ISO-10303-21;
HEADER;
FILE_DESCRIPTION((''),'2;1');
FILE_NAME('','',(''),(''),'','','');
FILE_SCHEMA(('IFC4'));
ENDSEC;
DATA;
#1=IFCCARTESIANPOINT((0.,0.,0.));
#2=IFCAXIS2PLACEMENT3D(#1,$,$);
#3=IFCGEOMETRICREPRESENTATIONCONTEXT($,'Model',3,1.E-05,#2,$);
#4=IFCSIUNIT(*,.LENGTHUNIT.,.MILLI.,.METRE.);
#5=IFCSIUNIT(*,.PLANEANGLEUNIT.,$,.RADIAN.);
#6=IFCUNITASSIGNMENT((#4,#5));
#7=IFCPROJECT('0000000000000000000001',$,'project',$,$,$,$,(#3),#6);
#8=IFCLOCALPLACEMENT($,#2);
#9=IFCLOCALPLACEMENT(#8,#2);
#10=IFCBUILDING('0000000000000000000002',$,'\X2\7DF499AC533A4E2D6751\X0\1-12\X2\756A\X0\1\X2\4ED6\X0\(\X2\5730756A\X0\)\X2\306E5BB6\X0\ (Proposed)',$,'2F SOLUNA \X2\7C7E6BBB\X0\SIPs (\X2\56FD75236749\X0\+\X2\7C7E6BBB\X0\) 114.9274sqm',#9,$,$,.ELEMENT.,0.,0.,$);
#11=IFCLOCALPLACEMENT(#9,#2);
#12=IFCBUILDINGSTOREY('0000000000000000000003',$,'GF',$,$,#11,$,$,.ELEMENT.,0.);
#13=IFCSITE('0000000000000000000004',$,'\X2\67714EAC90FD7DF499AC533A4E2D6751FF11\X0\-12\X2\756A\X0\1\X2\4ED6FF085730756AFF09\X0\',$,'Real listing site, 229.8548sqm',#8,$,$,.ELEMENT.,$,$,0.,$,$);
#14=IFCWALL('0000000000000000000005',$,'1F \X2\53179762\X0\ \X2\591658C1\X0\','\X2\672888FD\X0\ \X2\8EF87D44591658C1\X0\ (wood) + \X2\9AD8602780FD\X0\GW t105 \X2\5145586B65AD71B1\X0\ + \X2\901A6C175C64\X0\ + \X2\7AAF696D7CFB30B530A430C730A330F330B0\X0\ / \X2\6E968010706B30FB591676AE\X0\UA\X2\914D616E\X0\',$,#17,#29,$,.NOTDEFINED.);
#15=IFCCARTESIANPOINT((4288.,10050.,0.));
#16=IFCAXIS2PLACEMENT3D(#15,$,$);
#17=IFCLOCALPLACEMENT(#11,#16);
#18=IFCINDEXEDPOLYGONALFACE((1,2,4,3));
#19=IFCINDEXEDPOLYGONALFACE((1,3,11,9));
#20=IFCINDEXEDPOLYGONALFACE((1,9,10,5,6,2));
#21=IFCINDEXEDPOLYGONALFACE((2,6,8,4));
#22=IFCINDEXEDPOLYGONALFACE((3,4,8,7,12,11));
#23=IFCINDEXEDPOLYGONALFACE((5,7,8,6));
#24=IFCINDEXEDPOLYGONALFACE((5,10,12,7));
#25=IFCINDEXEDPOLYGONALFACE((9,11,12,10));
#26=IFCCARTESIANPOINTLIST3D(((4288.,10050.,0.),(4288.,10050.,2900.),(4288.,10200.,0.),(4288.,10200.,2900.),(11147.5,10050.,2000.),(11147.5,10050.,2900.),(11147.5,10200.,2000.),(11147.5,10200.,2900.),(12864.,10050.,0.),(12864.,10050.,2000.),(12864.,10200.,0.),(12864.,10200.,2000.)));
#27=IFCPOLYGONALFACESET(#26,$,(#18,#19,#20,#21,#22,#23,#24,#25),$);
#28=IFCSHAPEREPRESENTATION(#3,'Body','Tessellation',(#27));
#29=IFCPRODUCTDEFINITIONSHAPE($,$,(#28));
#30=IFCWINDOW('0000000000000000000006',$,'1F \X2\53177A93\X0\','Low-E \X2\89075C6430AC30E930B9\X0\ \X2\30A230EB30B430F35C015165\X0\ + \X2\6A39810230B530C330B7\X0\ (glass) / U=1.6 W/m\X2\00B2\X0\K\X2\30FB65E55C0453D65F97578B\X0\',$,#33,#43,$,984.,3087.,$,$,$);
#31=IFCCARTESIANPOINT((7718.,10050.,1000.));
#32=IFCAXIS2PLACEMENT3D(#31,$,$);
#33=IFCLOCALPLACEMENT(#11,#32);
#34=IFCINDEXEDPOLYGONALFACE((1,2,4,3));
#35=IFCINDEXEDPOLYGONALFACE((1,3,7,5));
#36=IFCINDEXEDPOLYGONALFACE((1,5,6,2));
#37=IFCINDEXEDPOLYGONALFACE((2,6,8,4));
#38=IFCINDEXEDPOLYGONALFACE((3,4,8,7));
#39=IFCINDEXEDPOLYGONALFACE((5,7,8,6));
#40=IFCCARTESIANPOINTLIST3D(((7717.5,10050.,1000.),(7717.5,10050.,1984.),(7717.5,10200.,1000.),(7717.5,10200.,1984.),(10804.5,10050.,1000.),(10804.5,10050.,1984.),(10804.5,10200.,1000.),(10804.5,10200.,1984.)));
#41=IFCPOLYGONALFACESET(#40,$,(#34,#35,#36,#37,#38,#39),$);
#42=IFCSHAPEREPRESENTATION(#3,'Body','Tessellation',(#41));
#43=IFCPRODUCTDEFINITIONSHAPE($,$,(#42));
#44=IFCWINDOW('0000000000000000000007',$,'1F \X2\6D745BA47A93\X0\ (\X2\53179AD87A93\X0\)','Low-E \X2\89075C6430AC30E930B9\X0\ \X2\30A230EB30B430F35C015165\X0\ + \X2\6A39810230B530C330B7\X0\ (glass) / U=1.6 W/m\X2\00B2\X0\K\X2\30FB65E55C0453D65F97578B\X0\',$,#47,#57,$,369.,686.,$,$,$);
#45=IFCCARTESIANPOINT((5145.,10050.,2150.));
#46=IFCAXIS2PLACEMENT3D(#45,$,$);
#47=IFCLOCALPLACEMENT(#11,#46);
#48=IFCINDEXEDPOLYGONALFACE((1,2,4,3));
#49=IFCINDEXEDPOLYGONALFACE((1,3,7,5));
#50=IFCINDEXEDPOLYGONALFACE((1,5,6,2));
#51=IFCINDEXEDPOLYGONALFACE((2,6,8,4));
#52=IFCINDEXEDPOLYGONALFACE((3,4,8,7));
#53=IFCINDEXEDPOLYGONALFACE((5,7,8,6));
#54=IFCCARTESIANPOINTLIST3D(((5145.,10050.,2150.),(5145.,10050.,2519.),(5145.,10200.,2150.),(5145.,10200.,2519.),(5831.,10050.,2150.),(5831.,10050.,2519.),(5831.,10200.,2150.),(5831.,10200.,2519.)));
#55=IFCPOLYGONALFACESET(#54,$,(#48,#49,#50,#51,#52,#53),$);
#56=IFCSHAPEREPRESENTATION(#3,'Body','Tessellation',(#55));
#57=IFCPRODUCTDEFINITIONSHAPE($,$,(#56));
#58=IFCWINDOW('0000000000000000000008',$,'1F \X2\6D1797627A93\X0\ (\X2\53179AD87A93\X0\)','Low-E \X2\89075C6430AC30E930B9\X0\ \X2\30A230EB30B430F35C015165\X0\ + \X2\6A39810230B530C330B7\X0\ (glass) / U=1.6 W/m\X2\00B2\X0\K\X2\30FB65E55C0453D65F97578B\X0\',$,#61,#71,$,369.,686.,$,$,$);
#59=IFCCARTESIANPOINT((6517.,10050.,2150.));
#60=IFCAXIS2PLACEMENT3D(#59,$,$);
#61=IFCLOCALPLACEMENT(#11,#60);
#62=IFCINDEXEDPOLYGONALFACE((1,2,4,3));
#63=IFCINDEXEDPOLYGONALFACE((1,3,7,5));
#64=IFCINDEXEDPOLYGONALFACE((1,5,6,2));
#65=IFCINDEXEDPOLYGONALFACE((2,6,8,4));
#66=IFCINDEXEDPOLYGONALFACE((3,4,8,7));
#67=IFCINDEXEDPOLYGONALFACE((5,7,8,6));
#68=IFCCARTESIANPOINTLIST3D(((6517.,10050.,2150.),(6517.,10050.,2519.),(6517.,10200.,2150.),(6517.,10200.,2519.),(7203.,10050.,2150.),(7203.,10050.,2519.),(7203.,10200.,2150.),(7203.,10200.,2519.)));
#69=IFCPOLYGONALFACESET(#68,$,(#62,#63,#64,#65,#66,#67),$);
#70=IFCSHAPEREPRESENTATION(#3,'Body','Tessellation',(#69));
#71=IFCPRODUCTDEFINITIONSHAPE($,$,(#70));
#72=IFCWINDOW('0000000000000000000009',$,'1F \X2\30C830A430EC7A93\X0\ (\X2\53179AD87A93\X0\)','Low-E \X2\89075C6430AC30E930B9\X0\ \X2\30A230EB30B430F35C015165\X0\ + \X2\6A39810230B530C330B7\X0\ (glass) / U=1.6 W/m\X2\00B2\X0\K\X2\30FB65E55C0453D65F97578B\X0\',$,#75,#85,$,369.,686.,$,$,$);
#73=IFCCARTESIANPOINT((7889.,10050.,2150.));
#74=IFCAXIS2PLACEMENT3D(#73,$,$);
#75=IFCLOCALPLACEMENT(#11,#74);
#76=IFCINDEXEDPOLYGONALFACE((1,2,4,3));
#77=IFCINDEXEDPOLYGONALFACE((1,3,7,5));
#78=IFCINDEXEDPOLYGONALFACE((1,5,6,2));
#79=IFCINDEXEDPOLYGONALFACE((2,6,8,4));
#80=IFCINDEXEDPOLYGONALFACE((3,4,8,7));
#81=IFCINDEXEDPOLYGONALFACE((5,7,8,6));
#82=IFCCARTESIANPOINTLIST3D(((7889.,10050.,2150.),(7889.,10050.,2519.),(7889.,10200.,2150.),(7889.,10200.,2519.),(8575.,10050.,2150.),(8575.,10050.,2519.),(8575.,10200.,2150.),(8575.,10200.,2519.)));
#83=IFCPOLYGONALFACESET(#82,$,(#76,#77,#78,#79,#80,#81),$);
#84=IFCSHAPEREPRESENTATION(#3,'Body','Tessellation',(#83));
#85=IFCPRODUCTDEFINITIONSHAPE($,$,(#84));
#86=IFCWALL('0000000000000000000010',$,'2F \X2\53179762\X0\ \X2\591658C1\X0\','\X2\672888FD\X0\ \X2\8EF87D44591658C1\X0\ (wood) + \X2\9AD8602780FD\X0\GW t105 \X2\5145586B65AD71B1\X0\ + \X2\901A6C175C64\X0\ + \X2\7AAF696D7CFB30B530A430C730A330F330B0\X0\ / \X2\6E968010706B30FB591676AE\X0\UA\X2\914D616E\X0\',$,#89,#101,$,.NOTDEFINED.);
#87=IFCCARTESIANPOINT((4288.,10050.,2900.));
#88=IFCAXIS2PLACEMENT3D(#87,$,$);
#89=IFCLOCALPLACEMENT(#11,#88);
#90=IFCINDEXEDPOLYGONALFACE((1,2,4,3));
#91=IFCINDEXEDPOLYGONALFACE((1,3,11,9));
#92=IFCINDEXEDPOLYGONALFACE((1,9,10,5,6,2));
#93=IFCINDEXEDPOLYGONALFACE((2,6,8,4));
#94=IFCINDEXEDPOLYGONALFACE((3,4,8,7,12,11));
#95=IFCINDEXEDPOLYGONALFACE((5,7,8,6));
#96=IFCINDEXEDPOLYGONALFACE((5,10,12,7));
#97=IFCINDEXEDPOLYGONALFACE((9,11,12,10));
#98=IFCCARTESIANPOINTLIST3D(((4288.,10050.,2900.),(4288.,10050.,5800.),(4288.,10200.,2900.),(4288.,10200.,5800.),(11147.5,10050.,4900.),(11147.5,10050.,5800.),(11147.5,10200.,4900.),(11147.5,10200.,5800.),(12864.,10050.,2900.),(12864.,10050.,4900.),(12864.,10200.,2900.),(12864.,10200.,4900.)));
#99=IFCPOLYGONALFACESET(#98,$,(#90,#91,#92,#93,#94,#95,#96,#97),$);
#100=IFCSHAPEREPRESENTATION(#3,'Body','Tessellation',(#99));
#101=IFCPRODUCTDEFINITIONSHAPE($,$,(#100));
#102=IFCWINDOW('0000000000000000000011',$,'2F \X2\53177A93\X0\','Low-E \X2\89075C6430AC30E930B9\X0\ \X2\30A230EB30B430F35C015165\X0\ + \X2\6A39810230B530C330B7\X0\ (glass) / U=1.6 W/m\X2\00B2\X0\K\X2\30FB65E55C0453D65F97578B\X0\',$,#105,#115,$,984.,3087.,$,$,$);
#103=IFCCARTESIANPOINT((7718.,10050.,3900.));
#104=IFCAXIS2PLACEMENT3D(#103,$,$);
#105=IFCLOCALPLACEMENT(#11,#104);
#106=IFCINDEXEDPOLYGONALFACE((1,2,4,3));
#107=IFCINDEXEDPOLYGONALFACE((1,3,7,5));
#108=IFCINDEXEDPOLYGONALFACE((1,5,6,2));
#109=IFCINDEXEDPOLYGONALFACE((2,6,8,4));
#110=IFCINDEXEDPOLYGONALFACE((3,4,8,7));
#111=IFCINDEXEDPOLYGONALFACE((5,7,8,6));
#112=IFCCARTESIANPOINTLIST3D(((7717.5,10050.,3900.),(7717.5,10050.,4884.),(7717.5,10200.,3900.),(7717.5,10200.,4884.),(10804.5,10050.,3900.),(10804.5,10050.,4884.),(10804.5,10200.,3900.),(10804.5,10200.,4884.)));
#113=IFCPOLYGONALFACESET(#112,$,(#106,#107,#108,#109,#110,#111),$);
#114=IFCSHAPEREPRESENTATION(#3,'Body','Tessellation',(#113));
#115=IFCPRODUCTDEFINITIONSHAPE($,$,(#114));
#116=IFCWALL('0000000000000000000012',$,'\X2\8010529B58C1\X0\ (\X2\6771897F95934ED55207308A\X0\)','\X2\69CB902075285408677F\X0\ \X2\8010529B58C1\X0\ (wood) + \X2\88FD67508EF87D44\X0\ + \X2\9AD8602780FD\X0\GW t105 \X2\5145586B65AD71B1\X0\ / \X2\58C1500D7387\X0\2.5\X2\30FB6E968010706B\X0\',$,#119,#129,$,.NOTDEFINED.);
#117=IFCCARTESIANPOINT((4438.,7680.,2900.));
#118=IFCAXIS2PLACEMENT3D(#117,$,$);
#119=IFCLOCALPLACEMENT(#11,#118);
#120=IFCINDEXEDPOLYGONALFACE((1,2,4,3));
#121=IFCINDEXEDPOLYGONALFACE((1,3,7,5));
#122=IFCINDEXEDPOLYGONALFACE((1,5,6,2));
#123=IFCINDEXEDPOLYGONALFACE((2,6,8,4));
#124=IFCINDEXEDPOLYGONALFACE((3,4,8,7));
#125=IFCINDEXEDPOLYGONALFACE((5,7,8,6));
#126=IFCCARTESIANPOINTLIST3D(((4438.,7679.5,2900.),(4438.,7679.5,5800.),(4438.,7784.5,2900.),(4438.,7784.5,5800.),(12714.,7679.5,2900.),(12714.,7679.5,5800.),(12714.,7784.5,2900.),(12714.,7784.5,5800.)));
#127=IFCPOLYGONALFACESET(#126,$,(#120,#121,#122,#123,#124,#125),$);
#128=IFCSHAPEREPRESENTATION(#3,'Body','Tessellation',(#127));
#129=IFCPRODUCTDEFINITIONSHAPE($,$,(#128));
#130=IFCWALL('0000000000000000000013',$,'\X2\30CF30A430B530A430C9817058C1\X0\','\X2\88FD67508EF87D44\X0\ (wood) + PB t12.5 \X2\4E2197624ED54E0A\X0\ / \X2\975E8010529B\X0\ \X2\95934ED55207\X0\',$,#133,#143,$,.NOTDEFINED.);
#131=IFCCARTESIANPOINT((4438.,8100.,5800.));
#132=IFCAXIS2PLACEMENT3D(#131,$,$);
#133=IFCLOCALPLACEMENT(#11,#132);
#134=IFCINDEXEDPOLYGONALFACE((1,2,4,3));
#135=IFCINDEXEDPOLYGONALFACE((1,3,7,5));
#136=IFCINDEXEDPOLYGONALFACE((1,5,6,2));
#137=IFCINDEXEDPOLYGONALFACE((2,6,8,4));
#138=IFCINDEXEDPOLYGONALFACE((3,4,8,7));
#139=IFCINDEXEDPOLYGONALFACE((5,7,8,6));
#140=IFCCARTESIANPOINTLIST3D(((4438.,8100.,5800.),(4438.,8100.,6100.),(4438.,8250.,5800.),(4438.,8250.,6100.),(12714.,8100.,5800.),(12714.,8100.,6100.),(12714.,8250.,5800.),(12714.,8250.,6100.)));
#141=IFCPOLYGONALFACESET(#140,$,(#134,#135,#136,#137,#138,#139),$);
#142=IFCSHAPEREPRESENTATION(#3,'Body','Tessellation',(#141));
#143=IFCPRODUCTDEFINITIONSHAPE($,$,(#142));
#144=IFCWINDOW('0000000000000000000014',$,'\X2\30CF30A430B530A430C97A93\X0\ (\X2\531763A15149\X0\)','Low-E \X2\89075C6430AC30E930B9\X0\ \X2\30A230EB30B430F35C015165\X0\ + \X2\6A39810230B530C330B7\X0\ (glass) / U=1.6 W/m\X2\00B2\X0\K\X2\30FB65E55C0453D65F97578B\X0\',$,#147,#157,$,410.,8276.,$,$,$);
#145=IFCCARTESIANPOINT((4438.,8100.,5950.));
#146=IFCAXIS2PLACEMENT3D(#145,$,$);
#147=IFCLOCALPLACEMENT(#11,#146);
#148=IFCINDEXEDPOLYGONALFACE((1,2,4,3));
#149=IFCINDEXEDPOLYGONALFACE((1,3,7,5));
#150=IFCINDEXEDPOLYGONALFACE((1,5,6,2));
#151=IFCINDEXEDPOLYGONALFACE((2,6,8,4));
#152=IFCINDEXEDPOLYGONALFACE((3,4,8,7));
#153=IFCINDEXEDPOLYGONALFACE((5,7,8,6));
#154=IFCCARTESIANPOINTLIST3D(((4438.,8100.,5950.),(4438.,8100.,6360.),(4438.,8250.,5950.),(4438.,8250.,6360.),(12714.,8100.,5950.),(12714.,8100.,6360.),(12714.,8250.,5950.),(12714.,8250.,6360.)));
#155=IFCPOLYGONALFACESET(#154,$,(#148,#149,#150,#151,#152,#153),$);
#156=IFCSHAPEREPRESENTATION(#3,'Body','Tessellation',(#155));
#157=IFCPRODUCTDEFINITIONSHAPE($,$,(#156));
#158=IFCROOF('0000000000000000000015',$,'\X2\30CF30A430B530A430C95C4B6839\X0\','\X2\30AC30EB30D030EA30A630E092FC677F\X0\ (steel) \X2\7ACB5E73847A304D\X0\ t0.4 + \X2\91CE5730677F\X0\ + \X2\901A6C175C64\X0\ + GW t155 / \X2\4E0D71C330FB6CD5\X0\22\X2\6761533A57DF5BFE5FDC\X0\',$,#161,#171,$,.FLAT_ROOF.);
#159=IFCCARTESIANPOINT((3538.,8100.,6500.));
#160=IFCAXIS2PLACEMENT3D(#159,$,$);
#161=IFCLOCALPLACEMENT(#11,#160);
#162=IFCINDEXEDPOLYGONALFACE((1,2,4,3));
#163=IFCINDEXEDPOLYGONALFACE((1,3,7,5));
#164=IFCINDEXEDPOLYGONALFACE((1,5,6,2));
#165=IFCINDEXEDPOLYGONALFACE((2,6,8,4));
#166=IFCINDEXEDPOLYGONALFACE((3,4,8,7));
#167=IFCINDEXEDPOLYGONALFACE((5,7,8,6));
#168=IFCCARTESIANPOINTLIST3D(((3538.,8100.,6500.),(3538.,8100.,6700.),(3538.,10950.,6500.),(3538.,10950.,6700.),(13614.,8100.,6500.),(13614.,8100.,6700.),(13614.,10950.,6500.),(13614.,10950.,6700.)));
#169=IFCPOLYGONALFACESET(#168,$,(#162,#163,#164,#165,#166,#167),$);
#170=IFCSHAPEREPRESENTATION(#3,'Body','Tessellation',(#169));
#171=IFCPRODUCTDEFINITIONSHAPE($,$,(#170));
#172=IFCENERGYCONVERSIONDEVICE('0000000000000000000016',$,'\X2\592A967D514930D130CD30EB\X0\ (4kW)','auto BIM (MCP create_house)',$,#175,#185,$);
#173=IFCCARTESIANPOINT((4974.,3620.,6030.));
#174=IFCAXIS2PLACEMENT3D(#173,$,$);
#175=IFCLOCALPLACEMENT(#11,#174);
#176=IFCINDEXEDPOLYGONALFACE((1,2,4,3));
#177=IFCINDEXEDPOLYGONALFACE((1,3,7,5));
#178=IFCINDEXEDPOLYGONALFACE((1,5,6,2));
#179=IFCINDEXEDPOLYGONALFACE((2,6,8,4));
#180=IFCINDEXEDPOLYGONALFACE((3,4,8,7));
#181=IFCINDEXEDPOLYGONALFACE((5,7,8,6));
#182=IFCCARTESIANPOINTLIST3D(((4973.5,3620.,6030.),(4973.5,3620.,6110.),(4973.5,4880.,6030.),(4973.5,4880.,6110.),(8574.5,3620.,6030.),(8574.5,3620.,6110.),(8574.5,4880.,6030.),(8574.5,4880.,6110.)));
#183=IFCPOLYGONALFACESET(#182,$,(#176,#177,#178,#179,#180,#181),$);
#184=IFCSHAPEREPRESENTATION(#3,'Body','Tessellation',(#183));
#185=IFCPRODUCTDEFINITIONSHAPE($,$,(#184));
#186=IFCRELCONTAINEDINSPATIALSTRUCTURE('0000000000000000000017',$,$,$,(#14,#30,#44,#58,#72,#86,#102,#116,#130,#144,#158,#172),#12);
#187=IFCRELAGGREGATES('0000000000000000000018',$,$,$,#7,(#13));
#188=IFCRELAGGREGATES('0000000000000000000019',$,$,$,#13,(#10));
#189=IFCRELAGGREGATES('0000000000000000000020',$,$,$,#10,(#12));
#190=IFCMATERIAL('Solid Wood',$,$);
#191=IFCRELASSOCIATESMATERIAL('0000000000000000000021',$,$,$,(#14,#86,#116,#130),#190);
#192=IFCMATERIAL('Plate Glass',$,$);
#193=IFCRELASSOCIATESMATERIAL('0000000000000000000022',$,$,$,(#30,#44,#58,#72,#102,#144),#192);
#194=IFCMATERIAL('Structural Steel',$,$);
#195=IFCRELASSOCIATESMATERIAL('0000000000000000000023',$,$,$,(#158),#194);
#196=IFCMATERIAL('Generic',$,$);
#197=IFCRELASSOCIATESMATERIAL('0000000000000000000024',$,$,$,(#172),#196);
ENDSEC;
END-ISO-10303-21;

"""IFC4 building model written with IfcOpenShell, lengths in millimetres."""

from ifc_helpers import new_model, si_unit, frame, frame_2d, origin, place, context, project, spatial, rectangle, extrude, material, element, fill, save


model = new_model("IFC4")

# Units and contexts
model_context = context("Model", 3, precision=1e-05, world=origin())
ifc_project = project(units=[si_unit("LENGTHUNIT", "METRE", prefix="MILLI"), si_unit("PLANEANGLEUNIT", "RADIAN")], contexts=[model_context])

# Site, building, storey
site_placement = place(None, origin())
site = spatial("IfcSite", under=ifc_project, at=site_placement, Name="東京都練馬区中村１-12番1他（地番）", ObjectType="Real listing site, 229.8548sqm", CompositionType="ELEMENT", RefElevation=0.0)
building_placement = place(site_placement, origin())
building = spatial("IfcBuilding", under=site, at=building_placement, Name="練馬区中村1-12番1他(地番)の家 (Proposed)", ObjectType="2F SOLUNA 籾殻SIPs (国産杉+籾殻) 114.9274sqm", CompositionType="ELEMENT", ElevationOfRefHeight=0.0, ElevationOfTerrain=0.0)
storey_placement = place(building_placement, origin())
storey = spatial("IfcBuildingStorey", under=building, at=storey_placement, Name="GF", CompositionType="ELEMENT", Elevation=0.0)

# Wall, openings, windows
ifc_material_1 = material(Name="Solid Wood")
wall_1_placement = place(storey_placement, frame((4288.0, 10050.0, 0.0)))
wall_1 = element("IfcWall", 1, at=wall_1_placement, inside=storey, material=ifc_material_1, Name="1F 北面 外壁", Description="木製 軸組外壁 (wood) + 高性能GW t105 充填断熱 + 通気層 + 窯業系サイディング / 準耐火・外皮UA配慮", PredefinedType="NOTDEFINED", context=model_context, shape_type="SweptSolid", body=[
    extrude(rectangle(XDim=8576.0, YDim=150.0, at=frame_2d((4288.0, 75.0))), frame((4288.0, 10050.0, 0.0)), (0.0, 0.0, 1.0), 2900.0),
])
opening_1_placement = place(storey_placement, frame((7718.0, 10050.0, 1000.0)))
opening_1 = element("IfcOpeningElement", 2, at=opening_1_placement, cuts=wall_1, PredefinedType="NOTDEFINED", context=model_context, shape_type="SweptSolid", body=[
    extrude(rectangle(XDim=3087.0, YDim=150.0, at=frame_2d((1543.0, 75.0))), frame((7718.0, 10050.0, 1000.0)), (0.0, 0.0, 1.0), 984.0),
])
opening_2_placement = place(storey_placement, frame((5145.0, 10050.0, 2150.0)))
opening_2 = element("IfcOpeningElement", 3, at=opening_2_placement, cuts=wall_1, PredefinedType="NOTDEFINED", context=model_context, shape_type="SweptSolid", body=[
    extrude(rectangle(XDim=686.0, YDim=150.0, at=frame_2d((343.0, 75.0))), frame((5145.0, 10050.0, 2150.0)), (0.0, 0.0, 1.0), 369.0),
])
opening_3_placement = place(storey_placement, frame((6517.0, 10050.0, 2150.0)))
opening_3 = element("IfcOpeningElement", 4, at=opening_3_placement, cuts=wall_1, PredefinedType="NOTDEFINED", context=model_context, shape_type="SweptSolid", body=[
    extrude(rectangle(XDim=686.0, YDim=150.0, at=frame_2d((343.0, 75.0))), frame((6517.0, 10050.0, 2150.0)), (0.0, 0.0, 1.0), 369.0),
])
opening_4_placement = place(storey_placement, frame((7889.0, 10050.0, 2150.0)))
opening_4 = element("IfcOpeningElement", 5, at=opening_4_placement, cuts=wall_1, PredefinedType="NOTDEFINED", context=model_context, shape_type="SweptSolid", body=[
    extrude(rectangle(XDim=686.0, YDim=150.0, at=frame_2d((343.0, 75.0))), frame((7889.0, 10050.0, 2150.0)), (0.0, 0.0, 1.0), 369.0),
])
ifc_material_2 = material(Name="Plate Glass")
window_1_placement = place(storey_placement, frame((7718.0, 10050.0, 1000.0)))
window_1 = element("IfcWindow", 6, at=window_1_placement, inside=storey, material=ifc_material_2, Name="1F 北窓", Description="Low-E 複層ガラス アルゴン封入 + 樹脂サッシ (glass) / U=1.6 W/m²K・日射取得型", OverallHeight=984.0, OverallWidth=3087.0, context=model_context, shape_type="SweptSolid", body=[
    extrude(rectangle(XDim=3087.0, YDim=150.0, at=frame_2d((1543.0, 75.0))), frame((7718.0, 10050.0, 1000.0)), (0.0, 0.0, 1.0), 984.0),
])
fill(opening_1, window_1)
window_2_placement = place(storey_placement, frame((5145.0, 10050.0, 2150.0)))
window_2 = element("IfcWindow", 7, at=window_2_placement, inside=storey, material=ifc_material_2, Name="1F 浴室窓 (北高窓)", Description="Low-E 複層ガラス アルゴン封入 + 樹脂サッシ (glass) / U=1.6 W/m²K・日射取得型", OverallHeight=369.0, OverallWidth=686.0, context=model_context, shape_type="SweptSolid", body=[
    extrude(rectangle(XDim=686.0, YDim=150.0, at=frame_2d((343.0, 75.0))), frame((5145.0, 10050.0, 2150.0)), (0.0, 0.0, 1.0), 369.0),
])
fill(opening_2, window_2)
window_3_placement = place(storey_placement, frame((6517.0, 10050.0, 2150.0)))
window_3 = element("IfcWindow", 8, at=window_3_placement, inside=storey, material=ifc_material_2, Name="1F 洗面窓 (北高窓)", Description="Low-E 複層ガラス アルゴン封入 + 樹脂サッシ (glass) / U=1.6 W/m²K・日射取得型", OverallHeight=369.0, OverallWidth=686.0, context=model_context, shape_type="SweptSolid", body=[
    extrude(rectangle(XDim=686.0, YDim=150.0, at=frame_2d((343.0, 75.0))), frame((6517.0, 10050.0, 2150.0)), (0.0, 0.0, 1.0), 369.0),
])
fill(opening_3, window_3)
window_4_placement = place(storey_placement, frame((7889.0, 10050.0, 2150.0)))
window_4 = element("IfcWindow", 9, at=window_4_placement, inside=storey, material=ifc_material_2, Name="1F トイレ窓 (北高窓)", Description="Low-E 複層ガラス アルゴン封入 + 樹脂サッシ (glass) / U=1.6 W/m²K・日射取得型", OverallHeight=369.0, OverallWidth=686.0, context=model_context, shape_type="SweptSolid", body=[
    extrude(rectangle(XDim=686.0, YDim=150.0, at=frame_2d((343.0, 75.0))), frame((7889.0, 10050.0, 2150.0)), (0.0, 0.0, 1.0), 369.0),
])
fill(opening_4, window_4)

# Wall, opening, window
wall_2_placement = place(storey_placement, frame((4288.0, 10050.0, 2900.0)))
wall_2 = element("IfcWall", 10, at=wall_2_placement, inside=storey, material=ifc_material_1, Name="2F 北面 外壁", Description="木製 軸組外壁 (wood) + 高性能GW t105 充填断熱 + 通気層 + 窯業系サイディング / 準耐火・外皮UA配慮", PredefinedType="NOTDEFINED", context=model_context, shape_type="SweptSolid", body=[
    extrude(rectangle(XDim=8576.0, YDim=150.0, at=frame_2d((4288.0, 75.0))), frame((4288.0, 10050.0, 2900.0)), (0.0, 0.0, 1.0), 2900.0),
])
opening_5_placement = place(storey_placement, frame((7718.0, 10050.0, 3900.0)))
opening_5 = element("IfcOpeningElement", 11, at=opening_5_placement, cuts=wall_2, PredefinedType="NOTDEFINED", context=model_context, shape_type="SweptSolid", body=[
    extrude(rectangle(XDim=3087.0, YDim=150.0, at=frame_2d((1543.0, 75.0))), frame((7718.0, 10050.0, 3900.0)), (0.0, 0.0, 1.0), 984.0),
])
window_5_placement = place(storey_placement, frame((7718.0, 10050.0, 3900.0)))
window_5 = element("IfcWindow", 12, at=window_5_placement, inside=storey, material=ifc_material_2, Name="2F 北窓", Description="Low-E 複層ガラス アルゴン封入 + 樹脂サッシ (glass) / U=1.6 W/m²K・日射取得型", OverallHeight=984.0, OverallWidth=3087.0, context=model_context, shape_type="SweptSolid", body=[
    extrude(rectangle(XDim=3087.0, YDim=150.0, at=frame_2d((1543.0, 75.0))), frame((7718.0, 10050.0, 3900.0)), (0.0, 0.0, 1.0), 984.0),
])
fill(opening_5, window_5)

# Wall
wall_3_placement = place(storey_placement, frame((4438.0, 7680.0, 2900.0)))
element("IfcWall", 13, at=wall_3_placement, inside=storey, material=ifc_material_1, Name="耐力壁 (東西間仕切り)", Description="構造用合板 耐力壁 (wood) + 製材軸組 + 高性能GW t105 充填断熱 / 壁倍率2.5・準耐火", PredefinedType="NOTDEFINED", context=model_context, shape_type="SweptSolid", body=[
    extrude(rectangle(XDim=8276.0, YDim=105.0, at=frame_2d((4138.0, 52.0))), frame((4438.0, 7680.0, 2900.0)), (0.0, 0.0, 1.0), 2900.0),
])

# Wall, opening, window
wall_4_placement = place(storey_placement, frame((4438.0, 8100.0, 5800.0)))
wall_4 = element("IfcWall", 14, at=wall_4_placement, inside=storey, material=ifc_material_1, Name="ハイサイド腰壁", Description="製材軸組 (wood) + PB t12.5 両面仕上 / 非耐力 間仕切", PredefinedType="NOTDEFINED", context=model_context, shape_type="SweptSolid", body=[
    extrude(rectangle(XDim=8276.0, YDim=150.0, at=frame_2d((4138.0, 75.0))), frame((4438.0, 8100.0, 5800.0)), (0.0, 0.0, 1.0), 700.0),
])
opening_6_placement = place(storey_placement, frame((4438.0, 8100.0, 5950.0)))
opening_6 = element("IfcOpeningElement", 15, at=opening_6_placement, cuts=wall_4, PredefinedType="NOTDEFINED", context=model_context, shape_type="SweptSolid", body=[
    extrude(rectangle(XDim=8276.0, YDim=150.0, at=frame_2d((4138.0, 75.0))), frame((4438.0, 8100.0, 5950.0)), (0.0, 0.0, 1.0), 410.0),
])
window_6_placement = place(storey_placement, frame((4438.0, 8100.0, 5950.0)))
window_6 = element("IfcWindow", 16, at=window_6_placement, inside=storey, material=ifc_material_2, Name="ハイサイド窓 (北採光)", Description="Low-E 複層ガラス アルゴン封入 + 樹脂サッシ (glass) / U=1.6 W/m²K・日射取得型", OverallHeight=410.0, OverallWidth=8276.0, context=model_context, shape_type="SweptSolid", body=[
    extrude(rectangle(XDim=8276.0, YDim=150.0, at=frame_2d((4138.0, 75.0))), frame((4438.0, 8100.0, 5950.0)), (0.0, 0.0, 1.0), 410.0),
])
fill(opening_6, window_6)

# Roof
ifc_material_3 = material(Name="Structural Steel")
roof_placement = place(storey_placement, frame((3538.0, 8100.0, 6500.0)))
element("IfcRoof", 17, at=roof_placement, inside=storey, material=ifc_material_3, Name="ハイサイド屋根", Description="ガルバリウム鋼板 (steel) 立平葺き t0.4 + 野地板 + 通気層 + GW t155 / 不燃・法22条区域対応", PredefinedType="FLAT_ROOF", context=model_context, shape_type="SweptSolid", body=[
    extrude(rectangle(XDim=10076.0, YDim=2850.0, at=frame_2d((5038.0, 1425.0))), frame((3538.0, 8100.0, 6500.0)), (0.0, 0.0, 1.0), 200.0),
])

# Energy conversion device
ifc_material_4 = material(Name="Generic")
energy_conversion_device_placement = place(storey_placement, frame((4974.0, 3620.0, 6030.0)))
element("IfcEnergyConversionDevice", 18, at=energy_conversion_device_placement, inside=storey, material=ifc_material_4, Name="太陽光パネル (4kW)", Description="auto BIM (MCP create_house)", context=model_context, shape_type="SweptSolid", body=[
    extrude(rectangle(XDim=3601.0, YDim=1260.0, at=frame_2d((1800.0, 630.0))), frame((4974.0, 3620.0, 6030.0)), (0.0, 0.0, 1.0), 80.0),
])

save(model, "model.ifc")
